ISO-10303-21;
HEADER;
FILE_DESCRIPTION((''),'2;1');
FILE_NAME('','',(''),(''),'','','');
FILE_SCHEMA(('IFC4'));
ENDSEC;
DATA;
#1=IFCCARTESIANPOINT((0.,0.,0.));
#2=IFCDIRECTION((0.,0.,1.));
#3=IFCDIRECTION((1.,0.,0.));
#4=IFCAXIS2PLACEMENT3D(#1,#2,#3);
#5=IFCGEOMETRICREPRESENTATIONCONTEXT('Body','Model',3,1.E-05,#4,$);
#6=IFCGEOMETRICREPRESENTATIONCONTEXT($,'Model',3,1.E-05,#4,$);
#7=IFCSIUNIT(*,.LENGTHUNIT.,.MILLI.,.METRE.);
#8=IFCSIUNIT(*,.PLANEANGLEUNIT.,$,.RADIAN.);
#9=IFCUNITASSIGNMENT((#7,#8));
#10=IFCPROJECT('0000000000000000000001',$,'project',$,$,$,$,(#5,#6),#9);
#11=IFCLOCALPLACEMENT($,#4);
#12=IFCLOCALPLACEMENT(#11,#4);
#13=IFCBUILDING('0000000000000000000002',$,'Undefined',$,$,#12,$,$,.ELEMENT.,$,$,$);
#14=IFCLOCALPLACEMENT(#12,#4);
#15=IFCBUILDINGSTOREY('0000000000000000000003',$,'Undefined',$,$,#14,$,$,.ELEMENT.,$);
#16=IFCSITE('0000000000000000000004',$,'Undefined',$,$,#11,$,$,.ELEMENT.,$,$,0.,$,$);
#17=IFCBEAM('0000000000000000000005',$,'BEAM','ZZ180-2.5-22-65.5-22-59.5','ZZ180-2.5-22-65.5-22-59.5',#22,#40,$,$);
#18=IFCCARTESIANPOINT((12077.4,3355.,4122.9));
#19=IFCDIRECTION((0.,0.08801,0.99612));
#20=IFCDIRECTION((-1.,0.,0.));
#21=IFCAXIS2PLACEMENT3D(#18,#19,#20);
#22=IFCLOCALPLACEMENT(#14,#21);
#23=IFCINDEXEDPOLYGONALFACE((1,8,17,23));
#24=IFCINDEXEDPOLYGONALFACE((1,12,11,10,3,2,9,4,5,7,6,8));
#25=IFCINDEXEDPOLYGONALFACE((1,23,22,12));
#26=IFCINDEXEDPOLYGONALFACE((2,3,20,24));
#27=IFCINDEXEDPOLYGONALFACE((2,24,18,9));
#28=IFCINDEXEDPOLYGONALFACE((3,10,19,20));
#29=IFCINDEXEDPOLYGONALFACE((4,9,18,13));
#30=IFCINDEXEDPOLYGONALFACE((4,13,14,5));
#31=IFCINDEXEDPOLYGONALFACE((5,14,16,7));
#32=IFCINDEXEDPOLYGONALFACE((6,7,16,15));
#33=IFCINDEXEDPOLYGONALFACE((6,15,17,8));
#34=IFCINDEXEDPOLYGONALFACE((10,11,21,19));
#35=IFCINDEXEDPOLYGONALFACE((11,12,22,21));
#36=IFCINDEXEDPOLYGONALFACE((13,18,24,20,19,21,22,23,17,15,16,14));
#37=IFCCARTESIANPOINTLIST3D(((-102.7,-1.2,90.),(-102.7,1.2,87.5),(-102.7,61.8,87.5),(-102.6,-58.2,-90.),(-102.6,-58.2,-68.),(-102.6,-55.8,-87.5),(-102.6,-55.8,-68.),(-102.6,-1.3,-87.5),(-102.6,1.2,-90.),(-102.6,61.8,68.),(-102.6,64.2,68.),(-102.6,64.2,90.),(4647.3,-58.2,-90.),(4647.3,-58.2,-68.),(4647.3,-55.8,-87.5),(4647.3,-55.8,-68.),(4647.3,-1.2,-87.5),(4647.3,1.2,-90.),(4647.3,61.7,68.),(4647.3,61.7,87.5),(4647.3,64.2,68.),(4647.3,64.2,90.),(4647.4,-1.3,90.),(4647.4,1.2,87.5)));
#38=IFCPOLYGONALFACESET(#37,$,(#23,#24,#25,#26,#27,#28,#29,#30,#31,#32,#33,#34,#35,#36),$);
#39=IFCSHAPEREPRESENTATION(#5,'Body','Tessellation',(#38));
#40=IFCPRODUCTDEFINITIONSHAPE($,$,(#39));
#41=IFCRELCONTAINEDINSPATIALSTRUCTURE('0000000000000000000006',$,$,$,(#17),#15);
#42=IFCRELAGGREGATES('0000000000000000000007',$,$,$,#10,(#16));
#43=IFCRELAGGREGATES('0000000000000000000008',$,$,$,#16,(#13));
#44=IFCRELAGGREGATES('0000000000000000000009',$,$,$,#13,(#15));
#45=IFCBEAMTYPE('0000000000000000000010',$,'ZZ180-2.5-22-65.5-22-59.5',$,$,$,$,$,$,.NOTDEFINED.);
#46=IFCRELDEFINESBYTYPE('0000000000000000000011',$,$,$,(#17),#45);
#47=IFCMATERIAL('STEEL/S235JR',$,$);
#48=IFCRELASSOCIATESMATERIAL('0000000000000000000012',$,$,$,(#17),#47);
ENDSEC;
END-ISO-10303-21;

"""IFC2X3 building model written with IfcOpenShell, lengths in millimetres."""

from ifc_helpers import new_model, si_unit, frame, origin_with_axes, place, context, project, spatial, polyline, outline, extrude, material, type_object, element, save


model = new_model("IFC2X3")

# Units and contexts
model_context_1 = context("Model", 3, precision=1e-05, world=origin_with_axes(), identifier="Body")
model_context_2 = context("Model", 3, precision=1e-05, world=origin_with_axes())
ifc_project = project(units=[si_unit("LENGTHUNIT", "METRE", prefix="MILLI"), si_unit("PLANEANGLEUNIT", "RADIAN")], contexts=[model_context_1, model_context_2])

# Site, building, storey
site_placement = place(None, origin_with_axes())
site = spatial("IfcSite", under=ifc_project, at=site_placement, Name="Undefined", CompositionType="ELEMENT", RefElevation=0.0)
building_placement = place(site_placement, origin_with_axes())
building = spatial("IfcBuilding", under=site, at=building_placement, Name="Undefined", CompositionType="ELEMENT")
storey_placement = place(building_placement, origin_with_axes())
storey = spatial("IfcBuildingStorey", under=building, at=storey_placement, Name="Undefined", CompositionType="ELEMENT")

# Shared definitions
ifc_material = material(Name="STEEL/S235JR")

# Beam
beam_type_1 = type_object("IfcBeamType", Name="ZZ180-2.5-22-65.5-22-59.5", PredefinedType="NOTDEFINED")
beam_1_placement = place(storey_placement, frame((12077.4, 3355.0, 4122.9), z_axis=(0.0, 0.08801, 0.99612), x_axis=(-1.0, 0.0, 0.0)))
element("IfcBeam", 1, at=beam_1_placement, inside=storey, type_object=beam_type_1, material=ifc_material, Name="BEAM", Description="ZZ180-2.5-22-65.5-22-59.5", ObjectType="ZZ180-2.5-22-65.5-22-59.5", context=model_context_1, shape_type="SweptSolid", body=[
    extrude(outline(polyline([(58.2, -90.0), (58.2, -68.0), (55.8, -68.0), (55.8, -87.5), (1.2, -87.5), (1.2, 90.0), (-64.2, 90.0), (-64.2, 68.0), (-61.8, 68.0), (-61.8, 87.5), (-1.2, 87.5), (-1.2, -90.0), (58.2, -90.0)])), frame((4647.4, 0.0, 0.0), z_axis=(-1.0, 0.0, 0.0), x_axis=(0.0, -1.0, 0.0)), (0.0, 0.0, 1.0), 4750.0),
])

save(model, "model.ifc")
